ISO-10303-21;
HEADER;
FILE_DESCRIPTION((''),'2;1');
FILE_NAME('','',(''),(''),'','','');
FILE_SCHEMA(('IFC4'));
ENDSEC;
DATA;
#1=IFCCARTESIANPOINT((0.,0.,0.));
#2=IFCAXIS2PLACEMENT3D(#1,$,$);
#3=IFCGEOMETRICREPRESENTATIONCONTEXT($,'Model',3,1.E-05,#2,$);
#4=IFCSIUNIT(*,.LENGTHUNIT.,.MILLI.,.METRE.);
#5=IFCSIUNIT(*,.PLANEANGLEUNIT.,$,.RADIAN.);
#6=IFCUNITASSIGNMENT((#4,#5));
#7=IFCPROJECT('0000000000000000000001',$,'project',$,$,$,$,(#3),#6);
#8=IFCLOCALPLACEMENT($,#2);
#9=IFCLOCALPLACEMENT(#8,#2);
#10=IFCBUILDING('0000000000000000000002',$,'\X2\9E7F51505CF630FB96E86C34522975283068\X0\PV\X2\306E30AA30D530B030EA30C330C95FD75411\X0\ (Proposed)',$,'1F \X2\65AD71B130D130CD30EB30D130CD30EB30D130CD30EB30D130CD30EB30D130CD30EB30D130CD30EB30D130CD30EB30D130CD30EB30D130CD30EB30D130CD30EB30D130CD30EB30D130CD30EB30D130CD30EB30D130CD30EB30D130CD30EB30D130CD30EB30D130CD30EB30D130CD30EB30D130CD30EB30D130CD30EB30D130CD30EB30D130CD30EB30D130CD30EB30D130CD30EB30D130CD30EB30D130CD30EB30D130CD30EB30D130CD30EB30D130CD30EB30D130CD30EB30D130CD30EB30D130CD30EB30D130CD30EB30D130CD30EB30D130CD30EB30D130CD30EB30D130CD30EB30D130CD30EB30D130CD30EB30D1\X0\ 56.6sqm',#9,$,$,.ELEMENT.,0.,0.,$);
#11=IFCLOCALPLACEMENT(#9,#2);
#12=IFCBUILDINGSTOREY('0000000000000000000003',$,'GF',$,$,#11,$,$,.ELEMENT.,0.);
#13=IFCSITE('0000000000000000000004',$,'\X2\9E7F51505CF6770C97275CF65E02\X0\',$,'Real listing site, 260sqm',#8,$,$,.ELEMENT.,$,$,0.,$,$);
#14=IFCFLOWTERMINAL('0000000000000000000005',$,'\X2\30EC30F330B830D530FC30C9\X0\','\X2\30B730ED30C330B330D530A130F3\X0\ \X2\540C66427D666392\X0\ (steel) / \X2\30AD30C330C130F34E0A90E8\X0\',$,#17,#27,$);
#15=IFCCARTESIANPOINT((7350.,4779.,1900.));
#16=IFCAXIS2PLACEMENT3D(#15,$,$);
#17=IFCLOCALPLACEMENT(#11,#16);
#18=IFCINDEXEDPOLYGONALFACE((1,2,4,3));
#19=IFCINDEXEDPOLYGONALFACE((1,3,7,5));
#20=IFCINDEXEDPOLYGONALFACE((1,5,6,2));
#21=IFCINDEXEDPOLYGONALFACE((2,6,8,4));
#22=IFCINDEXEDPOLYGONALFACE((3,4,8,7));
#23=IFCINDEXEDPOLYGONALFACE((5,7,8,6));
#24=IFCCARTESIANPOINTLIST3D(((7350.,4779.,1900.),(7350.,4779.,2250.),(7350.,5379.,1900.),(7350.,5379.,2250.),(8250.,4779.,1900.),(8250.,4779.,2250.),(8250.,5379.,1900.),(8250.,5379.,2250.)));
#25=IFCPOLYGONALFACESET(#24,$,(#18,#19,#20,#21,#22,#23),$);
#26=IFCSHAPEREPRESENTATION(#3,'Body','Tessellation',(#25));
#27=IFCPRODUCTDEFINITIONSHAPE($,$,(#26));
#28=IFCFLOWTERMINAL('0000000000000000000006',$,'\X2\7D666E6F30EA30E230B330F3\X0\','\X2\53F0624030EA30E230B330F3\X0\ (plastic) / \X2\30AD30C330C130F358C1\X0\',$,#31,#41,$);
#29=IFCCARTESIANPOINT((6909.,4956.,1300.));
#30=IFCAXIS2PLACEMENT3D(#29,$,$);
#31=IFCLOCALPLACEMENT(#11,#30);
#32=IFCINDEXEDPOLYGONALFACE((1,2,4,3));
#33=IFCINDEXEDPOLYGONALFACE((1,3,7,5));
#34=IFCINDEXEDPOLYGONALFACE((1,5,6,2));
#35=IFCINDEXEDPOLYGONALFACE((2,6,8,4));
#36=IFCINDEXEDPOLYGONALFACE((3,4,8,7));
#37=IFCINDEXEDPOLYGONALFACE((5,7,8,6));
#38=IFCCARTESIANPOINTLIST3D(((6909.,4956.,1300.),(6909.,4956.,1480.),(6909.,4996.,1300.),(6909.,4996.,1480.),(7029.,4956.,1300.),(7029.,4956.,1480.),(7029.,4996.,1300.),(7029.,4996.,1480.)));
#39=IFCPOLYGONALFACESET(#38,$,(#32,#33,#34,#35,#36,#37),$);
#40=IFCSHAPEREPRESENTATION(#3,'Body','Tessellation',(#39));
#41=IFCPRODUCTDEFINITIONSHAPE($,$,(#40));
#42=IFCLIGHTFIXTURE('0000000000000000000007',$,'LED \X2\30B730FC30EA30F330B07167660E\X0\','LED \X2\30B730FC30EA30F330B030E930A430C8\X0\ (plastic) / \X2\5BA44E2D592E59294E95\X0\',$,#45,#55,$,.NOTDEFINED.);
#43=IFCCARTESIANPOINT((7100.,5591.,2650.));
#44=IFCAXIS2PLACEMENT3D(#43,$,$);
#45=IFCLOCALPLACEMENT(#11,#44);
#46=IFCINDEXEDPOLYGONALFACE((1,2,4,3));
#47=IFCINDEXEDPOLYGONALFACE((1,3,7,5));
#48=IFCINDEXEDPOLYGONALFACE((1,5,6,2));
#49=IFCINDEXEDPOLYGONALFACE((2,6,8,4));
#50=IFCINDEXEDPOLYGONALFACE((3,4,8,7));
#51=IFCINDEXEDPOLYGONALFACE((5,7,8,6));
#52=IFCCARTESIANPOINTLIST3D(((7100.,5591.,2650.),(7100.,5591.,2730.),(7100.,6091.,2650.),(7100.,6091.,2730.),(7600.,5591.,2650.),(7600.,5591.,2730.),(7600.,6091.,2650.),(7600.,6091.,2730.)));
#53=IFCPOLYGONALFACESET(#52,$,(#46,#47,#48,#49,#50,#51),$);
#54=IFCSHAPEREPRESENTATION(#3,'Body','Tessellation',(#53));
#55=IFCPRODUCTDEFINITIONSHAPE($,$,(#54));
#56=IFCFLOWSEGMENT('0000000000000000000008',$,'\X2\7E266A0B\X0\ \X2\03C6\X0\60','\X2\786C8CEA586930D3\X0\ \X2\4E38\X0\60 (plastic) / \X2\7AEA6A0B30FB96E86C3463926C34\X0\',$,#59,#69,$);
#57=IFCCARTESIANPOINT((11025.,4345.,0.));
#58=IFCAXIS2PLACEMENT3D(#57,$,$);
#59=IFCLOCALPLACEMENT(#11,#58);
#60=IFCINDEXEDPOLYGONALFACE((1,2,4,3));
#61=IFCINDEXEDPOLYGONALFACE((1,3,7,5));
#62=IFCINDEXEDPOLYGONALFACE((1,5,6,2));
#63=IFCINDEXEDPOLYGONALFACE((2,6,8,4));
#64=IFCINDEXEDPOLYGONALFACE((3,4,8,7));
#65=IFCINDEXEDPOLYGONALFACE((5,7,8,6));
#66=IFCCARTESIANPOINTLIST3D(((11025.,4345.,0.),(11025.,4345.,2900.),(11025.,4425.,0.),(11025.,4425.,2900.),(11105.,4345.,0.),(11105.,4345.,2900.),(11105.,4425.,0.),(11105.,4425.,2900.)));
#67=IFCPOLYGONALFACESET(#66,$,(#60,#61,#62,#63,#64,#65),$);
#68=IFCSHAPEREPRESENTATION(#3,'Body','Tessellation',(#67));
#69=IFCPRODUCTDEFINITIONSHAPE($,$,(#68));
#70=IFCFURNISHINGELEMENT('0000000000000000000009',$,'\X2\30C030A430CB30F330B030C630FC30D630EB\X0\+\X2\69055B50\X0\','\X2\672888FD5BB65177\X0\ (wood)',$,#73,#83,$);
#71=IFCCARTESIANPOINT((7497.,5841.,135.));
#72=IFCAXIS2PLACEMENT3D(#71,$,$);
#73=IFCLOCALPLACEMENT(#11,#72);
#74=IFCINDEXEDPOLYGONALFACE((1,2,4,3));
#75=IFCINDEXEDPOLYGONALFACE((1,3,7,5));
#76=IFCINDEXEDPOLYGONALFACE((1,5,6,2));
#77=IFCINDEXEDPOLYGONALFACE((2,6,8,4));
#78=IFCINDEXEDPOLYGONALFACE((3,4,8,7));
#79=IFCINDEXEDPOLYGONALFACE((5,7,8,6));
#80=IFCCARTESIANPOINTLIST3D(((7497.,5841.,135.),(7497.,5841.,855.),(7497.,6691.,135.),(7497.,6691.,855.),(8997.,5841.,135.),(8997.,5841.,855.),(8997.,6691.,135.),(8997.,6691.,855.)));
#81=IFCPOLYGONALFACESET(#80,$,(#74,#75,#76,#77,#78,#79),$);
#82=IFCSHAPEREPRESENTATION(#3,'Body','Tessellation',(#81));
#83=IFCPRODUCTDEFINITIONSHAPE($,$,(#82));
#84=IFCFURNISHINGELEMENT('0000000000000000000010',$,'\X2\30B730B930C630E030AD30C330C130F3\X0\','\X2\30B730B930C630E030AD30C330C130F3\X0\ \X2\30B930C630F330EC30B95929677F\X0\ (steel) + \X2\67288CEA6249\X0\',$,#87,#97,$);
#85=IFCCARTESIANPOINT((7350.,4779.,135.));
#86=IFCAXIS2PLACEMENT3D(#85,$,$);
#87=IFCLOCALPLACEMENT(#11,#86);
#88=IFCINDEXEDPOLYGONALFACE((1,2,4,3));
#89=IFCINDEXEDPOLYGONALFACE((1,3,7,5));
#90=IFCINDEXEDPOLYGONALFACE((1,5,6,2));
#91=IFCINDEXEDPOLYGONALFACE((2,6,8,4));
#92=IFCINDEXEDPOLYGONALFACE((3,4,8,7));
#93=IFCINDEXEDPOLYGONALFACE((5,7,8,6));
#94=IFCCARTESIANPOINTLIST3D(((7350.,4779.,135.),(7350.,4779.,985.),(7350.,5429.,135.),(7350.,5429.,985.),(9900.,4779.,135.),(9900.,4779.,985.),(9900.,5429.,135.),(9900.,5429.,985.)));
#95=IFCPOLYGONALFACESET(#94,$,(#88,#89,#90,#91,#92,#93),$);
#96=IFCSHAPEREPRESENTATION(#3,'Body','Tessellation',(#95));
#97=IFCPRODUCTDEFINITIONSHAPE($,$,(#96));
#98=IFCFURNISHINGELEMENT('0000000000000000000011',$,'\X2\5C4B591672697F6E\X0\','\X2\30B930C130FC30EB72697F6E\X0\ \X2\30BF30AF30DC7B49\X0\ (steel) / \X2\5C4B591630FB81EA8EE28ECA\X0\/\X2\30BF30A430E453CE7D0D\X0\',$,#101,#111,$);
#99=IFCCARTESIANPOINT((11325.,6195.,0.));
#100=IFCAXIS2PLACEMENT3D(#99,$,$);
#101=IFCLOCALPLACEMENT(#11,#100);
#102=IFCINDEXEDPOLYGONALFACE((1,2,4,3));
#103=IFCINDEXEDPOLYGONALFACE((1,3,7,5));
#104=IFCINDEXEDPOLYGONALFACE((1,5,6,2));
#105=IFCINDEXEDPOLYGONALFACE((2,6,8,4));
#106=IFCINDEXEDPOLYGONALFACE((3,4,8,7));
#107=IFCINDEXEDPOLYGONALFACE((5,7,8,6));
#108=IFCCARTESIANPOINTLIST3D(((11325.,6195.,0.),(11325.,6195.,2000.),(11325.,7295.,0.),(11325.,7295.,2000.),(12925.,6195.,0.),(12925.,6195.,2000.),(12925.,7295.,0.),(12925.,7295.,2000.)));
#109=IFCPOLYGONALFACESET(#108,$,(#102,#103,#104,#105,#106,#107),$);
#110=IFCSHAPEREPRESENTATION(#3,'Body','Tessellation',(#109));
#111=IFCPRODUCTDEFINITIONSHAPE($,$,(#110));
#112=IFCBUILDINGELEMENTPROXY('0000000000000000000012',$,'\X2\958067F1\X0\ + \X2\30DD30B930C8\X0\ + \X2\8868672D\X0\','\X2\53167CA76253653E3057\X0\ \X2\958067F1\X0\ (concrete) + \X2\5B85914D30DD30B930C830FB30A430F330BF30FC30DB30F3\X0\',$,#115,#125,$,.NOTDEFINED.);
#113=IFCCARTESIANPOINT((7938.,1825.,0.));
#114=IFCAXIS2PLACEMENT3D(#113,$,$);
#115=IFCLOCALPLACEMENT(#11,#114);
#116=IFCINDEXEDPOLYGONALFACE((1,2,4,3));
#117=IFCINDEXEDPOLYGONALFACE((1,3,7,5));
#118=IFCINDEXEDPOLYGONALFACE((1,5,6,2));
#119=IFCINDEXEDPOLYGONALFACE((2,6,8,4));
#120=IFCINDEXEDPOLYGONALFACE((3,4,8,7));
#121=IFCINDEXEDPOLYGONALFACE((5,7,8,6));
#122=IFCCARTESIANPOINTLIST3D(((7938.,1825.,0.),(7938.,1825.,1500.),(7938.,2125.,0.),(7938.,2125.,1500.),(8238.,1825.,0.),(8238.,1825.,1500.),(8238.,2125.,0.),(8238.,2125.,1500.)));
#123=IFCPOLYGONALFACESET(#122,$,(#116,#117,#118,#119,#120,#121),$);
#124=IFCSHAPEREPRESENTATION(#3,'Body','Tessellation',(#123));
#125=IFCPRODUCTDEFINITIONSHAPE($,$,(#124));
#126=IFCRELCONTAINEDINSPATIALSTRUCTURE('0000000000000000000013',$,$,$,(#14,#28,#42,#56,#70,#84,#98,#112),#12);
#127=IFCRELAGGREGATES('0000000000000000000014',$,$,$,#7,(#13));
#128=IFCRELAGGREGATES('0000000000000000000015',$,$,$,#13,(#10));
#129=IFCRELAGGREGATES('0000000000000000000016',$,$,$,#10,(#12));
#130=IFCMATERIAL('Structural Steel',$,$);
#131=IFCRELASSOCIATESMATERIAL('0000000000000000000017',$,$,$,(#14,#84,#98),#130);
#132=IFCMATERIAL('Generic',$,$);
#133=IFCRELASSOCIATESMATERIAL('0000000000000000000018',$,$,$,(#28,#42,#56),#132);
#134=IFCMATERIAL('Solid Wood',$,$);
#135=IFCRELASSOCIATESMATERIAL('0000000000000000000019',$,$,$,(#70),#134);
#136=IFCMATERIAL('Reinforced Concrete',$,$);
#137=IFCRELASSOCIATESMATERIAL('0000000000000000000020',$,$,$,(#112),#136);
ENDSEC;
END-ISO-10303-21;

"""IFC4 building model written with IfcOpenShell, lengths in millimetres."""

from ifc_helpers import new_model, si_unit, frame, frame_2d, origin, place, context, project, spatial, rectangle, extrude, material, element, save


model = new_model("IFC4")

# Units and contexts
model_context = context("Model", 3, precision=1e-05, world=origin())
ifc_project = project(units=[si_unit("LENGTHUNIT", "METRE", prefix="MILLI"), si_unit("PLANEANGLEUNIT", "RADIAN")], contexts=[model_context])

# Site, building, storey
site_placement = place(None, origin())
site = spatial("IfcSite", under=ifc_project, at=site_placement, Name="鹿児島県霧島市", ObjectType="Real listing site, 260sqm", CompositionType="ELEMENT", RefElevation=0.0)
building_placement = place(site_placement, origin())
building = spatial("IfcBuilding", under=site, at=building_placement, Name="鹿児島・雨水利用とPVのオフグリッド志向 (Proposed)", ObjectType="1F 断熱パネルパネルパネルパネルパネルパネルパネルパネルパネルパネルパネルパネルパネルパネルパネルパネルパネルパネルパネルパネルパネルパネルパネルパネルパネルパネルパネルパネルパネルパネルパネルパネルパネルパネルパネルパネルパネルパネルパネルパ 56.6sqm", CompositionType="ELEMENT", ElevationOfRefHeight=0.0, ElevationOfTerrain=0.0)
storey_placement = place(building_placement, origin())
storey = spatial("IfcBuildingStorey", under=building, at=storey_placement, Name="GF", CompositionType="ELEMENT", Elevation=0.0)

# Shared definitions
ifc_material_1 = material(Name="Solid Wood")

# Shared definitions
ifc_material_2 = material(Name="Structural Steel")

# Shared definitions
ifc_material_3 = material(Name="Reinforced Concrete")

# Flow terminals
flow_terminal_1_placement = place(storey_placement, frame((7350.0, 4779.0, 1900.0)))
element("IfcFlowTerminal", 1, at=flow_terminal_1_placement, inside=storey, material=ifc_material_2, Name="レンジフード", Description="シロッコファン 同時給排 (steel) / キッチン上部", context=model_context, shape_type="SweptSolid", body=[
    extrude(rectangle(XDim=900.0, YDim=600.0, at=frame_2d((450.0, 300.0))), frame((7350.0, 4779.0, 1900.0)), (0.0, 0.0, 1.0), 350.0),
])
ifc_material_4 = material(Name="Generic")
flow_terminal_2_placement = place(storey_placement, frame((6909.0, 4956.0, 1300.0)))
element("IfcFlowTerminal", 2, at=flow_terminal_2_placement, inside=storey, material=ifc_material_4, Name="給湯リモコン", Description="台所リモコン (plastic) / キッチン壁", context=model_context, shape_type="SweptSolid", body=[
    extrude(rectangle(XDim=120.0, YDim=40.0, at=frame_2d((60.0, 20.0))), frame((6909.0, 4956.0, 1300.0)), (0.0, 0.0, 1.0), 180.0),
])

# Light fixture
light_fixture_placement = place(storey_placement, frame((7100.0, 5591.0, 2650.0)))
element("IfcLightFixture", 3, at=light_fixture_placement, inside=storey, material=ifc_material_4, Name="LED シーリング照明", Description="LED シーリングライト (plastic) / 室中央天井", PredefinedType="NOTDEFINED", context=model_context, shape_type="SweptSolid", body=[
    extrude(rectangle(XDim=500.0, YDim=500.0, at=frame_2d((250.0, 250.0))), frame((7100.0, 5591.0, 2650.0)), (0.0, 0.0, 1.0), 80.0),
])

# Flow segment
flow_segment_placement = place(storey_placement, frame((11025.0, 4345.0, 0.0)))
element("IfcFlowSegment", 4, at=flow_segment_placement, inside=storey, material=ifc_material_4, Name="縦樋 φ60", Description="硬質塩ビ 丸60 (plastic) / 竪樋・雨水排水", context=model_context, shape_type="SweptSolid", body=[
    extrude(rectangle(XDim=80.0, YDim=80.0, at=frame_2d((40.0, 40.0))), frame((11025.0, 4345.0, 0.0)), (0.0, 0.0, 1.0), 2900.0),
])

# Furnishing elements
furnishing_1_placement = place(storey_placement, frame((7497.0, 5841.0, 135.0)))
element("IfcFurnishingElement", 5, at=furnishing_1_placement, inside=storey, material=ifc_material_1, Name="ダイニングテーブル+椅子", Description="木製家具 (wood)", context=model_context, shape_type="SweptSolid", body=[
    extrude(rectangle(XDim=1500.0, YDim=850.0, at=frame_2d((750.0, 425.0))), frame((7497.0, 5841.0, 135.0)), (0.0, 0.0, 1.0), 720.0),
])
furnishing_2_placement = place(storey_placement, frame((7350.0, 4779.0, 135.0)))
element("IfcFurnishingElement", 6, at=furnishing_2_placement, inside=storey, material=ifc_material_2, Name="システムキッチン", Description="システムキッチン ステンレス天板 (steel) + 木質扉", context=model_context, shape_type="SweptSolid", body=[
    extrude(rectangle(XDim=2550.0, YDim=650.0, at=frame_2d((1275.0, 325.0))), frame((7350.0, 4779.0, 135.0)), (0.0, 0.0, 1.0), 850.0),
])
furnishing_3_placement = place(storey_placement, frame((11325.0, 6195.0, 0.0)))
element("IfcFurnishingElement", 7, at=furnishing_3_placement, inside=storey, material=ifc_material_2, Name="屋外物置", Description="スチール物置 タクボ等 (steel) / 屋外・自転車/タイヤ収納", context=model_context, shape_type="SweptSolid", body=[
    extrude(rectangle(XDim=1600.0, YDim=1100.0, at=frame_2d((800.0, 550.0))), frame((11325.0, 6195.0, 0.0)), (0.0, 0.0, 1.0), 2000.0),
])

# Building element proxy
proxy_placement = place(storey_placement, frame((7938.0, 1825.0, 0.0)))
element("IfcBuildingElementProxy", 8, at=proxy_placement, inside=storey, material=ifc_material_3, Name="門柱 + ポスト + 表札", Description="化粧打放し 門柱 (concrete) + 宅配ポスト・インターホン", PredefinedType="NOTDEFINED", context=model_context, shape_type="SweptSolid", body=[
    extrude(rectangle(XDim=300.0, YDim=300.0, at=frame_2d((150.0, 150.0))), frame((7938.0, 1825.0, 0.0)), (0.0, 0.0, 1.0), 1500.0),
])

save(model, "model.ifc")
